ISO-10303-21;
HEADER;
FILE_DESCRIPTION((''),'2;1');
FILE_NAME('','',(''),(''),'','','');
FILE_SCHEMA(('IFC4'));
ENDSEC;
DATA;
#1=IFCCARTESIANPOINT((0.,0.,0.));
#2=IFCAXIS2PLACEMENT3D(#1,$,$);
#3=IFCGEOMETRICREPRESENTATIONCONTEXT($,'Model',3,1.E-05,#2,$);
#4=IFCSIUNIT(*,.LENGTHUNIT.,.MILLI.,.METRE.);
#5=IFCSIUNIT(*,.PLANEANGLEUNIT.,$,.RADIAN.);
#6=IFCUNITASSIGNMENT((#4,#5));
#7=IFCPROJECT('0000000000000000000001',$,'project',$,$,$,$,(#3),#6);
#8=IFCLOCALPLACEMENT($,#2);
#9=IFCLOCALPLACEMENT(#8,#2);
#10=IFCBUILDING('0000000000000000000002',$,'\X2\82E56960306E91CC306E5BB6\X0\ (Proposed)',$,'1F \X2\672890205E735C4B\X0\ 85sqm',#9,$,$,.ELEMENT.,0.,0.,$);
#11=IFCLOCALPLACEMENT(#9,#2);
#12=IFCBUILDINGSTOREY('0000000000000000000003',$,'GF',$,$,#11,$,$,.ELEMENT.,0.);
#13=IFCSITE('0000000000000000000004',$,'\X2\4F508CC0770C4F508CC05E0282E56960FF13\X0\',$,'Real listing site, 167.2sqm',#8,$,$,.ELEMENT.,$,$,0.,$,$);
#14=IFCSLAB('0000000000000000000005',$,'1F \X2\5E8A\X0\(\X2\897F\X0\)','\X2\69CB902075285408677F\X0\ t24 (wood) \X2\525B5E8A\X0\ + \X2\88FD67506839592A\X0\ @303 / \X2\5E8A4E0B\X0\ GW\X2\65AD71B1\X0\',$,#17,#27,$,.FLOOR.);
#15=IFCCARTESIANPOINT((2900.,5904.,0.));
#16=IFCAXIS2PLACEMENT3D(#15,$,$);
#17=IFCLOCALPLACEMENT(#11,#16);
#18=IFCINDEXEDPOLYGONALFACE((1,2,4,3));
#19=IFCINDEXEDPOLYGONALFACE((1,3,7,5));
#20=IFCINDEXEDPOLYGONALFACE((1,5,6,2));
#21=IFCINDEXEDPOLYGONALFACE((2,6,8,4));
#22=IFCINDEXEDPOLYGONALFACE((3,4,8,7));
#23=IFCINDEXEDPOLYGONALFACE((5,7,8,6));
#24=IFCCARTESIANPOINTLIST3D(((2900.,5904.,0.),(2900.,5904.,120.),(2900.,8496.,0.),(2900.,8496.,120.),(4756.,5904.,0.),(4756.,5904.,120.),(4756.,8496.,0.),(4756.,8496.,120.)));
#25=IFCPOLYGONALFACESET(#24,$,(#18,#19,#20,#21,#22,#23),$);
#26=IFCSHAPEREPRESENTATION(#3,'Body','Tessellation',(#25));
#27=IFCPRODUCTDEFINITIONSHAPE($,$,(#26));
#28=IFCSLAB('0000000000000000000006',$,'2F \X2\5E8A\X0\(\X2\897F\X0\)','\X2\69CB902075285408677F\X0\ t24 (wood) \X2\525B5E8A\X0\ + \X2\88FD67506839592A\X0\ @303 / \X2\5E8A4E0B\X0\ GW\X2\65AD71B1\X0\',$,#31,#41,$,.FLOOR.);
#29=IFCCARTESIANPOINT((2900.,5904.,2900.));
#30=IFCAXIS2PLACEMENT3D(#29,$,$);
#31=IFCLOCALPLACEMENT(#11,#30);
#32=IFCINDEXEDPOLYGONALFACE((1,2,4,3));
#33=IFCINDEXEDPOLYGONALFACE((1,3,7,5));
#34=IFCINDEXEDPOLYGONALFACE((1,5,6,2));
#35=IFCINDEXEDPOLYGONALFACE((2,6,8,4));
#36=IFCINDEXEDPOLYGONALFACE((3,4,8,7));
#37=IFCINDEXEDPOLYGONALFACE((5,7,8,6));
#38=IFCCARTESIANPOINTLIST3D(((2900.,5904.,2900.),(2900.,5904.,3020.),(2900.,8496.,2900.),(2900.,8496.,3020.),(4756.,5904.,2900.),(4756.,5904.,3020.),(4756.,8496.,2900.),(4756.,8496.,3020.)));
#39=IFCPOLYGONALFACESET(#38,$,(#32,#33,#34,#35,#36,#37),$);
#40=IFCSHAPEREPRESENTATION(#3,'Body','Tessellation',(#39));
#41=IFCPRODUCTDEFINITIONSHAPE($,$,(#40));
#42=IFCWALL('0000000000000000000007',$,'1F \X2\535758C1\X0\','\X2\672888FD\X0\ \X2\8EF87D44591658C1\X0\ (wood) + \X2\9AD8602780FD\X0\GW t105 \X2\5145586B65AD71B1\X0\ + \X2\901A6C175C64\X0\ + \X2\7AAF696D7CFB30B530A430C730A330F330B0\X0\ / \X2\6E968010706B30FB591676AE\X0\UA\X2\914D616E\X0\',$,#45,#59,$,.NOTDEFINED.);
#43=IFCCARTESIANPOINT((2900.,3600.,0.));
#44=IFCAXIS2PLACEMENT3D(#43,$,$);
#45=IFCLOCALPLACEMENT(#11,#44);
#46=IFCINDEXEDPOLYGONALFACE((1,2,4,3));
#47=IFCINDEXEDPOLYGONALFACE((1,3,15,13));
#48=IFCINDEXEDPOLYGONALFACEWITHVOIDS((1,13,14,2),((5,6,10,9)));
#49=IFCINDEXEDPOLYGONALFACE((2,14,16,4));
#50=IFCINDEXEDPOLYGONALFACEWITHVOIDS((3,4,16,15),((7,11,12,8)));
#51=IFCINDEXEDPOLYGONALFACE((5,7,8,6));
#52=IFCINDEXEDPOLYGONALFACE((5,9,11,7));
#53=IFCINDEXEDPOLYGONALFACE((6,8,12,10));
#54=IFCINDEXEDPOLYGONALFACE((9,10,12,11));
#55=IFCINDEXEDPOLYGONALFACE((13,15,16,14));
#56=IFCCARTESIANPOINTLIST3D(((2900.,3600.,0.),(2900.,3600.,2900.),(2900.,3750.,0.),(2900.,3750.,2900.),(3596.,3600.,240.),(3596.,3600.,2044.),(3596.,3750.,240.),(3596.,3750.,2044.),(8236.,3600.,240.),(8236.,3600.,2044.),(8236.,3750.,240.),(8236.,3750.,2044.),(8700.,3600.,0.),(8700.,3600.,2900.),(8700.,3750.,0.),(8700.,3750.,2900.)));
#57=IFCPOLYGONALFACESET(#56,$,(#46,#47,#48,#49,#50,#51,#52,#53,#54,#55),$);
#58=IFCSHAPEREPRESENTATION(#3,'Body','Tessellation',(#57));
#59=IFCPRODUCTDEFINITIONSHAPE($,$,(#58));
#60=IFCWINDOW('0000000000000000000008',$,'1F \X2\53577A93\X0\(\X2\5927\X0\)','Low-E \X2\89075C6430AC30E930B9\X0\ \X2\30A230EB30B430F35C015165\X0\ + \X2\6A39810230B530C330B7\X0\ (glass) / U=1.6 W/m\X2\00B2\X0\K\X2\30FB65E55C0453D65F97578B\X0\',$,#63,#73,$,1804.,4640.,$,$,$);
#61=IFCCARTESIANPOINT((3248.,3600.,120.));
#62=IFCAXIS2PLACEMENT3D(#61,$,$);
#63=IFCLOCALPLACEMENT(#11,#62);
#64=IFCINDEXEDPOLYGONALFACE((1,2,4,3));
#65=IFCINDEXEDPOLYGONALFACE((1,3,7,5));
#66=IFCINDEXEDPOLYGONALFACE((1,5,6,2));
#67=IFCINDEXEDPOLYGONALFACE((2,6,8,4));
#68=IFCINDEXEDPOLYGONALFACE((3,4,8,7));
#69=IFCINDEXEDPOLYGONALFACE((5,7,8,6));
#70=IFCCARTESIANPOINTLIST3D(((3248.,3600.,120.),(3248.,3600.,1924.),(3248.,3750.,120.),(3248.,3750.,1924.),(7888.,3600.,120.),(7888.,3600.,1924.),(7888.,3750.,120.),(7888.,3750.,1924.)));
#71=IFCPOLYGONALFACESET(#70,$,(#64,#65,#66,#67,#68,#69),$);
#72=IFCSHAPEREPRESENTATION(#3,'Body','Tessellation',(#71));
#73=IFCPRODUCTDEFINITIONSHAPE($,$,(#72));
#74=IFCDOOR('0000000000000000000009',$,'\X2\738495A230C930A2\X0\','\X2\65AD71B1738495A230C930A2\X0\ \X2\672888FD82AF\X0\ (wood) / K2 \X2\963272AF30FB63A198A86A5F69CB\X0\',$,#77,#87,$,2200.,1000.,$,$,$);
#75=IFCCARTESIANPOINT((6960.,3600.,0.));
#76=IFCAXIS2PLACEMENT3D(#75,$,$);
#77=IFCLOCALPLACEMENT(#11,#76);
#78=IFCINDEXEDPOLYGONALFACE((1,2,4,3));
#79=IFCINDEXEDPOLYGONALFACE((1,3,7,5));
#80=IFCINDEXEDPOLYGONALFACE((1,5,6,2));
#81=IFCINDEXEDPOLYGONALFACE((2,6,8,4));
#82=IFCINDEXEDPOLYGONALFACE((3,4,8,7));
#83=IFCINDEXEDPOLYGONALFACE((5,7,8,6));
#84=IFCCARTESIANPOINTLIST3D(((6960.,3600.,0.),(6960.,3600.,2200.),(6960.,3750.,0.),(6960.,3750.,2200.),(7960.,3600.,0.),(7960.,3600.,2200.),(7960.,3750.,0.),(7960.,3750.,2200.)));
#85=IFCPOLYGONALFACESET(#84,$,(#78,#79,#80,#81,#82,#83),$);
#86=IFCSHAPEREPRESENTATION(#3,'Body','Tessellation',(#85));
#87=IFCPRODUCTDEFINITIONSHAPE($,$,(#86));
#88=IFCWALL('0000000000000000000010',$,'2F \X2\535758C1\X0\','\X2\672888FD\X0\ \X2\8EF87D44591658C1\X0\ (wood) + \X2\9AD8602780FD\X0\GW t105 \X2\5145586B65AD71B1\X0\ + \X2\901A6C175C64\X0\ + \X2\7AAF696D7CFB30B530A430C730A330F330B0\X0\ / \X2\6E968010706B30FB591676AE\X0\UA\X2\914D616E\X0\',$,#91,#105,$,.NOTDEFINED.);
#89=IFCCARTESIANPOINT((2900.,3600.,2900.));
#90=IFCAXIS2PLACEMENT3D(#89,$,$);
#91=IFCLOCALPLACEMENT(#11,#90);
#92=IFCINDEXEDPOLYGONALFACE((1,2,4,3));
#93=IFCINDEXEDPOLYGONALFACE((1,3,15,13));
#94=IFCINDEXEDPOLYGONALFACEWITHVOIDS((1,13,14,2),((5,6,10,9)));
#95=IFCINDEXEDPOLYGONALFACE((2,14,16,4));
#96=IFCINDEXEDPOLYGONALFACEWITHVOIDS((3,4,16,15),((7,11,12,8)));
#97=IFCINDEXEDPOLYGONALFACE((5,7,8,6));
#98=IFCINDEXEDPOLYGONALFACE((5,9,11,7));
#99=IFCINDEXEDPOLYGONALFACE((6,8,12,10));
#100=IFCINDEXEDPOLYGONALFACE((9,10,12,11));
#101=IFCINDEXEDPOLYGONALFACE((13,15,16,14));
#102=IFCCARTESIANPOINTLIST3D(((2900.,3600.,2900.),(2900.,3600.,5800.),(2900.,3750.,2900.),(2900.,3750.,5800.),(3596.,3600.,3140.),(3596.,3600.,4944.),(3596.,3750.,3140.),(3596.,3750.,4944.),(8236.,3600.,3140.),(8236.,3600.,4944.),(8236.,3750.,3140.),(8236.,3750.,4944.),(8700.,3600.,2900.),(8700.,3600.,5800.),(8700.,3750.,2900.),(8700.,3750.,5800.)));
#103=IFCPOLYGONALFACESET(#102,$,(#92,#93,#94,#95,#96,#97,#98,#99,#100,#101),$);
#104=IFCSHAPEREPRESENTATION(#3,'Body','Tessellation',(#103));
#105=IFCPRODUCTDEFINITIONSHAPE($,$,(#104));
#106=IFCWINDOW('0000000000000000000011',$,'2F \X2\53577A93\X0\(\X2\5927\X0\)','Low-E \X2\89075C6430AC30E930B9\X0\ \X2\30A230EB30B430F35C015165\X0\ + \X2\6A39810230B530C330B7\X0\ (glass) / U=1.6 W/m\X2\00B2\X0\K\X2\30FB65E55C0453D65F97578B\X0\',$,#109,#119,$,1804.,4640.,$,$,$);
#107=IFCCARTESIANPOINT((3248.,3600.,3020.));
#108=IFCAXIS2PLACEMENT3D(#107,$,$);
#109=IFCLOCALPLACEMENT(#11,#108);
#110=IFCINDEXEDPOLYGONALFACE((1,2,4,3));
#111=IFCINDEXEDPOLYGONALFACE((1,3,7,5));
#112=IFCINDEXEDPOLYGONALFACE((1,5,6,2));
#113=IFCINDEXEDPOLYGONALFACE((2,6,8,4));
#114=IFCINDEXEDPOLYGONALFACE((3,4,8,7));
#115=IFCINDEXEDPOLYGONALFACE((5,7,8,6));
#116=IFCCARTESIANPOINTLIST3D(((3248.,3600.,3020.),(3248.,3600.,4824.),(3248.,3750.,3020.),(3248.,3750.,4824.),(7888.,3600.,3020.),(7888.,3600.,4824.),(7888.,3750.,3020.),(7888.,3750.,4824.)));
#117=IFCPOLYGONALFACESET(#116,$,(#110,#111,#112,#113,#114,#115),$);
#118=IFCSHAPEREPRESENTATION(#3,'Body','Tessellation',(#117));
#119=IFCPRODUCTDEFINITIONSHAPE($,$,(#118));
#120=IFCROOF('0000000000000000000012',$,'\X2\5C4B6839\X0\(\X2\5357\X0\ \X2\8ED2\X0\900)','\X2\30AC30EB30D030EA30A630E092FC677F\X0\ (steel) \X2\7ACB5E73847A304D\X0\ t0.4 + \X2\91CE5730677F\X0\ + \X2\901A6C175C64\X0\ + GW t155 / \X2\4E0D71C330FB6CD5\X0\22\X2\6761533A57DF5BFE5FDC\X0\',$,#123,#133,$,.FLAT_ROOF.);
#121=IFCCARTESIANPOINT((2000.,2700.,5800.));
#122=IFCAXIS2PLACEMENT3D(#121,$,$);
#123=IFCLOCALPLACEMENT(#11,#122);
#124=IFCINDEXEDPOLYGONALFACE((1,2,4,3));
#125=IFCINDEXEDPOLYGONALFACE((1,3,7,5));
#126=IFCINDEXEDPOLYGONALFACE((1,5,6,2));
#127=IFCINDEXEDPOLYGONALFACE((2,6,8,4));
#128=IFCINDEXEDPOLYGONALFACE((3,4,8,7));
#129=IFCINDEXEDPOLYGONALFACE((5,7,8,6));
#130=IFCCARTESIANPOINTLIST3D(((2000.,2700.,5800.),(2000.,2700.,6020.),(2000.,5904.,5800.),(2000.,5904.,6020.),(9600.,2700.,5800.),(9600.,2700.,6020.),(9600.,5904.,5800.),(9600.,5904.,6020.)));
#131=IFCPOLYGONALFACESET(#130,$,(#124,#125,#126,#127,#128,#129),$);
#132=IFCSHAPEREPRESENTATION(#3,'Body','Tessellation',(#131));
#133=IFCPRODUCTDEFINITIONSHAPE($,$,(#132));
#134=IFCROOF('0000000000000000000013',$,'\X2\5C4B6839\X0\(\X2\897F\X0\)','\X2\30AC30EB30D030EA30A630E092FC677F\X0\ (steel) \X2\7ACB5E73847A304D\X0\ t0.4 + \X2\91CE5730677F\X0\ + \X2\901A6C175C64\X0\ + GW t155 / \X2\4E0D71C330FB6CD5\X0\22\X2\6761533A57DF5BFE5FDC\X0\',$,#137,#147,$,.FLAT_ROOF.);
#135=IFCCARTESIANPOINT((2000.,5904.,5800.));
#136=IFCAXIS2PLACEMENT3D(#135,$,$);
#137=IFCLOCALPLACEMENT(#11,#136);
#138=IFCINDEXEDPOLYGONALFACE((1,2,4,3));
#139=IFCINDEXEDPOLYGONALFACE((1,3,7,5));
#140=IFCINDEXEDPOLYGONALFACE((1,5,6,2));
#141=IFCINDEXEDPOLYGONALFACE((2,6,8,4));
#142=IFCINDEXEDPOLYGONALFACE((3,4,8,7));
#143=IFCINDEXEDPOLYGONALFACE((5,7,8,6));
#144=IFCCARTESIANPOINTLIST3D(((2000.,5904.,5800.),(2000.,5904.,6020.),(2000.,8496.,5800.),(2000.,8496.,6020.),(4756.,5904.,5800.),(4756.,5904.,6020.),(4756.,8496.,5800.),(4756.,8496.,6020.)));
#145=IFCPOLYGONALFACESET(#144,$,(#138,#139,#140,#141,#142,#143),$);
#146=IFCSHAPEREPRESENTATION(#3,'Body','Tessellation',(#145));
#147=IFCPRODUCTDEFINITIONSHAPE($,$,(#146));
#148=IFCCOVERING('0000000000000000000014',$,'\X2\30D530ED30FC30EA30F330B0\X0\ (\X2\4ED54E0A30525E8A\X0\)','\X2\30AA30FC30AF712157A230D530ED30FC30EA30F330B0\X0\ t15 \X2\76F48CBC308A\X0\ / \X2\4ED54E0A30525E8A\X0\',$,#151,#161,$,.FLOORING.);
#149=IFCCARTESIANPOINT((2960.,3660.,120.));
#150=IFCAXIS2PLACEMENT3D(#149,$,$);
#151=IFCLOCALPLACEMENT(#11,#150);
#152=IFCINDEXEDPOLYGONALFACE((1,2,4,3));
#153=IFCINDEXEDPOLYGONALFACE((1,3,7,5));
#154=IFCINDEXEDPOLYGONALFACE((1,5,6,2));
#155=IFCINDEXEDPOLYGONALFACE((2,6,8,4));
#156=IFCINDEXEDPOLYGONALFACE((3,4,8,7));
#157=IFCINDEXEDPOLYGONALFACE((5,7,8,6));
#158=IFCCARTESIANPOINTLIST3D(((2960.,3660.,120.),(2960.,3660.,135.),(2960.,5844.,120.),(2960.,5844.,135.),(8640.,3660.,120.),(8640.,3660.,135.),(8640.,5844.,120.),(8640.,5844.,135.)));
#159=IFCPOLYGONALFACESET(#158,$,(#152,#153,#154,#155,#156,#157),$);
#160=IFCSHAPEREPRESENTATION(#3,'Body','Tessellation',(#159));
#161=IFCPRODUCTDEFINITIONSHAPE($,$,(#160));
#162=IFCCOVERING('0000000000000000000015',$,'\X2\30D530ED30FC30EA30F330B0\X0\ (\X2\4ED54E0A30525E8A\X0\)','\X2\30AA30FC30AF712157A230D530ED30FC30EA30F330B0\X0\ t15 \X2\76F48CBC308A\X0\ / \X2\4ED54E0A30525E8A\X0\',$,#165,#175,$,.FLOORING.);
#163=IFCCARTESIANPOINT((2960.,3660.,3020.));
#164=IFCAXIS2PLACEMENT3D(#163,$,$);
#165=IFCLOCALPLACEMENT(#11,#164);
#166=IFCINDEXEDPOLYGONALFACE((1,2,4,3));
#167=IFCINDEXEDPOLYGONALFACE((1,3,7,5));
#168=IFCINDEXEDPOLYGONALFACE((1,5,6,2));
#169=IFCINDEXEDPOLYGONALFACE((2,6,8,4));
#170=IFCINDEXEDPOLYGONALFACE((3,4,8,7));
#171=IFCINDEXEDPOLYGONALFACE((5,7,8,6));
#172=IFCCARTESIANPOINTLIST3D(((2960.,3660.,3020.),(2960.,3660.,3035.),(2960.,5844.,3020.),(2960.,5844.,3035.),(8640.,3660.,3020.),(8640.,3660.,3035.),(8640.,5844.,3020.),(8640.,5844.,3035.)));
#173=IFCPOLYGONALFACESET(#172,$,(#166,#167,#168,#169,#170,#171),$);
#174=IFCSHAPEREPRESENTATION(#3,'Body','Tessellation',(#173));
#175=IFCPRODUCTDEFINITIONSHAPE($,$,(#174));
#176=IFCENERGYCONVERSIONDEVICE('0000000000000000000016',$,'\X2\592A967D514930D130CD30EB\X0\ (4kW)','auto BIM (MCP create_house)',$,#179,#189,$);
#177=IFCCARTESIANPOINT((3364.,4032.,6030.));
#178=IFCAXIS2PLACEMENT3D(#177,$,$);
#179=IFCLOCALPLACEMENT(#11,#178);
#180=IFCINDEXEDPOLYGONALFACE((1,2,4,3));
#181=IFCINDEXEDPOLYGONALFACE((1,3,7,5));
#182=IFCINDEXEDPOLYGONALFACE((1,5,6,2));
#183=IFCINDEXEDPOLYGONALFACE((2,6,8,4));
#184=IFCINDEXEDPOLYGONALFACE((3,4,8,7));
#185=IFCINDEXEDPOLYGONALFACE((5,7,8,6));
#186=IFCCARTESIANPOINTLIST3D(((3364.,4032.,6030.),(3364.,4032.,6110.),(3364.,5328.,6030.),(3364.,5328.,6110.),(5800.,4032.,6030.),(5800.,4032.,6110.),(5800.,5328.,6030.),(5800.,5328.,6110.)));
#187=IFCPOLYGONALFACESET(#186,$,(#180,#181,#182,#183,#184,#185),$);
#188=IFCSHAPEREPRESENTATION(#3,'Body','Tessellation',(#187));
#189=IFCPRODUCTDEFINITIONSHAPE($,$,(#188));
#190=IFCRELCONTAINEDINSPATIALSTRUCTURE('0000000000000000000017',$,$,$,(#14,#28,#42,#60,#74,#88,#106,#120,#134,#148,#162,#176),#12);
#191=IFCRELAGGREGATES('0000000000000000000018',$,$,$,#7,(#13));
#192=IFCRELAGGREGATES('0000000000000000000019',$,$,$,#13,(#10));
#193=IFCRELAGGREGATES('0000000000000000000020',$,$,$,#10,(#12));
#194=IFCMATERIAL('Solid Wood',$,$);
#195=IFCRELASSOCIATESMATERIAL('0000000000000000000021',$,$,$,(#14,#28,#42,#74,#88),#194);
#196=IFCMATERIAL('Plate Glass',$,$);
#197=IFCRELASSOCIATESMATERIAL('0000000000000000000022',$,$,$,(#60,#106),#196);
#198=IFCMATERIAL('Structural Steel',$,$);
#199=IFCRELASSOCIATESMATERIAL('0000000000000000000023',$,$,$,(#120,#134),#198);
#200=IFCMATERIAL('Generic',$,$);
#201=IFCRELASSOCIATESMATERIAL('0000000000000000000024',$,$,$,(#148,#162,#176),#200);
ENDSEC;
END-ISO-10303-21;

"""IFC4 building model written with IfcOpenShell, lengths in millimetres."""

from ifc_helpers import new_model, si_unit, frame, frame_2d, origin, place, context, project, spatial, rectangle, extrude, material, element, fill, save


model = new_model("IFC4")

# Units and contexts
model_context = context("Model", 3, precision=1e-05, world=origin())
ifc_project = project(units=[si_unit("LENGTHUNIT", "METRE", prefix="MILLI"), si_unit("PLANEANGLEUNIT", "RADIAN")], contexts=[model_context])

# Site, building, storey
site_placement = place(None, origin())
site = spatial("IfcSite", under=ifc_project, at=site_placement, Name="佐賀県佐賀市若楠３", ObjectType="Real listing site, 167.2sqm", CompositionType="ELEMENT", RefElevation=0.0)
building_placement = place(site_placement, origin())
building = spatial("IfcBuilding", under=site, at=building_placement, Name="若楠の里の家 (Proposed)", ObjectType="1F 木造平屋 85sqm", CompositionType="ELEMENT", ElevationOfRefHeight=0.0, ElevationOfTerrain=0.0)
storey_placement = place(building_placement, origin())
storey = spatial("IfcBuildingStorey", under=building, at=storey_placement, Name="GF", CompositionType="ELEMENT", Elevation=0.0)

# Slabs
ifc_material_1 = material(Name="Solid Wood")
slab_1_placement = place(storey_placement, frame((2900.0, 5904.0, 0.0)))
element("IfcSlab", 1, at=slab_1_placement, inside=storey, material=ifc_material_1, Name="1F 床(西)", Description="構造用合板 t24 (wood) 剛床 + 製材根太 @303 / 床下 GW断熱", PredefinedType="FLOOR", context=model_context, shape_type="SweptSolid", body=[
    extrude(rectangle(XDim=1856.0, YDim=2592.0, at=frame_2d((928.0, 1296.0))), frame((2900.0, 5904.0, 0.0)), (0.0, 0.0, 1.0), 120.0),
])
slab_2_placement = place(storey_placement, frame((2900.0, 5904.0, 2900.0)))
element("IfcSlab", 2, at=slab_2_placement, inside=storey, material=ifc_material_1, Name="2F 床(西)", Description="構造用合板 t24 (wood) 剛床 + 製材根太 @303 / 床下 GW断熱", PredefinedType="FLOOR", context=model_context, shape_type="SweptSolid", body=[
    extrude(rectangle(XDim=1856.0, YDim=2592.0, at=frame_2d((928.0, 1296.0))), frame((2900.0, 5904.0, 2900.0)), (0.0, 0.0, 1.0), 120.0),
])
ifc_material_2 = material(Name="Generic")

# Wall, openings, window, door
wall_1_placement = place(storey_placement, frame((2900.0, 3600.0, 0.0)))
wall_1 = element("IfcWall", 3, at=wall_1_placement, inside=storey, material=ifc_material_1, Name="1F 南壁", Description="木製 軸組外壁 (wood) + 高性能GW t105 充填断熱 + 通気層 + 窯業系サイディング / 準耐火・外皮UA配慮", PredefinedType="NOTDEFINED", context=model_context, shape_type="SweptSolid", body=[
    extrude(rectangle(XDim=5800.0, YDim=150.0, at=frame_2d((2900.0, 75.0))), frame((2900.0, 3600.0, 0.0)), (0.0, 0.0, 1.0), 2900.0),
])
opening_1_placement = place(storey_placement, frame((3248.0, 3600.0, 120.0)))
opening_1 = element("IfcOpeningElement", 4, at=opening_1_placement, cuts=wall_1, PredefinedType="NOTDEFINED", context=model_context, shape_type="SweptSolid", body=[
    extrude(rectangle(XDim=4640.0, YDim=150.0, at=frame_2d((2320.0, 75.0))), frame((3248.0, 3600.0, 120.0)), (0.0, 0.0, 1.0), 1804.0),
])
opening_2_placement = place(storey_placement, frame((6960.0, 3600.0, 0.0)))
opening_2 = element("IfcOpeningElement", 5, at=opening_2_placement, cuts=wall_1, PredefinedType="NOTDEFINED", context=model_context, shape_type="SweptSolid", body=[
    extrude(rectangle(XDim=1000.0, YDim=150.0, at=frame_2d((500.0, 75.0))), frame((6960.0, 3600.0, 0.0)), (0.0, 0.0, 1.0), 2200.0),
])
ifc_material_3 = material(Name="Plate Glass")
window_1_placement = place(storey_placement, frame((3248.0, 3600.0, 120.0)))
window_1 = element("IfcWindow", 6, at=window_1_placement, inside=storey, material=ifc_material_3, Name="1F 南窓(大)", Description="Low-E 複層ガラス アルゴン封入 + 樹脂サッシ (glass) / U=1.6 W/m²K・日射取得型", OverallHeight=1804.0, OverallWidth=4640.0, context=model_context, shape_type="SweptSolid", body=[
    extrude(rectangle(XDim=4640.0, YDim=150.0, at=frame_2d((2320.0, 75.0))), frame((3248.0, 3600.0, 120.0)), (0.0, 0.0, 1.0), 1804.0),
])
fill(opening_1, window_1)
door_placement = place(storey_placement, frame((6960.0, 3600.0, 0.0)))
door = element("IfcDoor", 7, at=door_placement, inside=storey, material=ifc_material_1, Name="玄関ドア", Description="断熱玄関ドア 木製芯 (wood) / K2 防犯・採風機構", OverallHeight=2200.0, OverallWidth=1000.0, context=model_context, shape_type="SweptSolid", body=[
    extrude(rectangle(XDim=1000.0, YDim=150.0, at=frame_2d((500.0, 75.0))), frame((6960.0, 3600.0, 0.0)), (0.0, 0.0, 1.0), 2200.0),
])
fill(opening_2, door)

# Wall, opening, window
wall_2_placement = place(storey_placement, frame((2900.0, 3600.0, 2900.0)))
wall_2 = element("IfcWall", 8, at=wall_2_placement, inside=storey, material=ifc_material_1, Name="2F 南壁", Description="木製 軸組外壁 (wood) + 高性能GW t105 充填断熱 + 通気層 + 窯業系サイディング / 準耐火・外皮UA配慮", PredefinedType="NOTDEFINED", context=model_context, shape_type="SweptSolid", body=[
    extrude(rectangle(XDim=5800.0, YDim=150.0, at=frame_2d((2900.0, 75.0))), frame((2900.0, 3600.0, 2900.0)), (0.0, 0.0, 1.0), 2900.0),
])
opening_3_placement = place(storey_placement, frame((3248.0, 3600.0, 3020.0)))
opening_3 = element("IfcOpeningElement", 9, at=opening_3_placement, cuts=wall_2, PredefinedType="NOTDEFINED", context=model_context, shape_type="SweptSolid", body=[
    extrude(rectangle(XDim=4640.0, YDim=150.0, at=frame_2d((2320.0, 75.0))), frame((3248.0, 3600.0, 3020.0)), (0.0, 0.0, 1.0), 1804.0),
])
window_2_placement = place(storey_placement, frame((3248.0, 3600.0, 3020.0)))
window_2 = element("IfcWindow", 10, at=window_2_placement, inside=storey, material=ifc_material_3, Name="2F 南窓(大)", Description="Low-E 複層ガラス アルゴン封入 + 樹脂サッシ (glass) / U=1.6 W/m²K・日射取得型", OverallHeight=1804.0, OverallWidth=4640.0, context=model_context, shape_type="SweptSolid", body=[
    extrude(rectangle(XDim=4640.0, YDim=150.0, at=frame_2d((2320.0, 75.0))), frame((3248.0, 3600.0, 3020.0)), (0.0, 0.0, 1.0), 1804.0),
])
fill(opening_3, window_2)

# Roofs
ifc_material_4 = material(Name="Structural Steel")
roof_1_placement = place(storey_placement, frame((2000.0, 2700.0, 5800.0)))
element("IfcRoof", 11, at=roof_1_placement, inside=storey, material=ifc_material_4, Name="屋根(南 軒900)", Description="ガルバリウム鋼板 (steel) 立平葺き t0.4 + 野地板 + 通気層 + GW t155 / 不燃・法22条区域対応", PredefinedType="FLAT_ROOF", context=model_context, shape_type="SweptSolid", body=[
    extrude(rectangle(XDim=7600.0, YDim=3204.0, at=frame_2d((3800.0, 1602.0))), frame((2000.0, 2700.0, 5800.0)), (0.0, 0.0, 1.0), 220.0),
])
roof_2_placement = place(storey_placement, frame((2000.0, 5904.0, 5800.0)))
element("IfcRoof", 12, at=roof_2_placement, inside=storey, material=ifc_material_4, Name="屋根(西)", Description="ガルバリウム鋼板 (steel) 立平葺き t0.4 + 野地板 + 通気層 + GW t155 / 不燃・法22条区域対応", PredefinedType="FLAT_ROOF", context=model_context, shape_type="SweptSolid", body=[
    extrude(rectangle(XDim=2756.0, YDim=2592.0, at=frame_2d((1378.0, 1296.0))), frame((2000.0, 5904.0, 5800.0)), (0.0, 0.0, 1.0), 220.0),
])

# Coverings
covering_1_placement = place(storey_placement, frame((2960.0, 3660.0, 120.0)))
element("IfcCovering", 13, at=covering_1_placement, inside=storey, material=ifc_material_2, Name="フローリング (仕上げ床)", Description="オーク無垢フローリング t15 直貼り / 仕上げ床", PredefinedType="FLOORING", context=model_context, shape_type="SweptSolid", body=[
    extrude(rectangle(XDim=5680.0, YDim=2184.0, at=frame_2d((2840.0, 1092.0))), frame((2960.0, 3660.0, 120.0)), (0.0, 0.0, 1.0), 15.0),
])
covering_2_placement = place(storey_placement, frame((2960.0, 3660.0, 3020.0)))
element("IfcCovering", 14, at=covering_2_placement, inside=storey, material=ifc_material_2, Name="フローリング (仕上げ床)", Description="オーク無垢フローリング t15 直貼り / 仕上げ床", PredefinedType="FLOORING", context=model_context, shape_type="SweptSolid", body=[
    extrude(rectangle(XDim=5680.0, YDim=2184.0, at=frame_2d((2840.0, 1092.0))), frame((2960.0, 3660.0, 3020.0)), (0.0, 0.0, 1.0), 15.0),
])

# Energy conversion device
energy_conversion_device_placement = place(storey_placement, frame((3364.0, 4032.0, 6030.0)))
element("IfcEnergyConversionDevice", 15, at=energy_conversion_device_placement, inside=storey, material=ifc_material_2, Name="太陽光パネル (4kW)", Description="auto BIM (MCP create_house)", context=model_context, shape_type="SweptSolid", body=[
    extrude(rectangle(XDim=2436.0, YDim=1296.0, at=frame_2d((1218.0, 648.0))), frame((3364.0, 4032.0, 6030.0)), (0.0, 0.0, 1.0), 80.0),
])

save(model, "model.ifc")
